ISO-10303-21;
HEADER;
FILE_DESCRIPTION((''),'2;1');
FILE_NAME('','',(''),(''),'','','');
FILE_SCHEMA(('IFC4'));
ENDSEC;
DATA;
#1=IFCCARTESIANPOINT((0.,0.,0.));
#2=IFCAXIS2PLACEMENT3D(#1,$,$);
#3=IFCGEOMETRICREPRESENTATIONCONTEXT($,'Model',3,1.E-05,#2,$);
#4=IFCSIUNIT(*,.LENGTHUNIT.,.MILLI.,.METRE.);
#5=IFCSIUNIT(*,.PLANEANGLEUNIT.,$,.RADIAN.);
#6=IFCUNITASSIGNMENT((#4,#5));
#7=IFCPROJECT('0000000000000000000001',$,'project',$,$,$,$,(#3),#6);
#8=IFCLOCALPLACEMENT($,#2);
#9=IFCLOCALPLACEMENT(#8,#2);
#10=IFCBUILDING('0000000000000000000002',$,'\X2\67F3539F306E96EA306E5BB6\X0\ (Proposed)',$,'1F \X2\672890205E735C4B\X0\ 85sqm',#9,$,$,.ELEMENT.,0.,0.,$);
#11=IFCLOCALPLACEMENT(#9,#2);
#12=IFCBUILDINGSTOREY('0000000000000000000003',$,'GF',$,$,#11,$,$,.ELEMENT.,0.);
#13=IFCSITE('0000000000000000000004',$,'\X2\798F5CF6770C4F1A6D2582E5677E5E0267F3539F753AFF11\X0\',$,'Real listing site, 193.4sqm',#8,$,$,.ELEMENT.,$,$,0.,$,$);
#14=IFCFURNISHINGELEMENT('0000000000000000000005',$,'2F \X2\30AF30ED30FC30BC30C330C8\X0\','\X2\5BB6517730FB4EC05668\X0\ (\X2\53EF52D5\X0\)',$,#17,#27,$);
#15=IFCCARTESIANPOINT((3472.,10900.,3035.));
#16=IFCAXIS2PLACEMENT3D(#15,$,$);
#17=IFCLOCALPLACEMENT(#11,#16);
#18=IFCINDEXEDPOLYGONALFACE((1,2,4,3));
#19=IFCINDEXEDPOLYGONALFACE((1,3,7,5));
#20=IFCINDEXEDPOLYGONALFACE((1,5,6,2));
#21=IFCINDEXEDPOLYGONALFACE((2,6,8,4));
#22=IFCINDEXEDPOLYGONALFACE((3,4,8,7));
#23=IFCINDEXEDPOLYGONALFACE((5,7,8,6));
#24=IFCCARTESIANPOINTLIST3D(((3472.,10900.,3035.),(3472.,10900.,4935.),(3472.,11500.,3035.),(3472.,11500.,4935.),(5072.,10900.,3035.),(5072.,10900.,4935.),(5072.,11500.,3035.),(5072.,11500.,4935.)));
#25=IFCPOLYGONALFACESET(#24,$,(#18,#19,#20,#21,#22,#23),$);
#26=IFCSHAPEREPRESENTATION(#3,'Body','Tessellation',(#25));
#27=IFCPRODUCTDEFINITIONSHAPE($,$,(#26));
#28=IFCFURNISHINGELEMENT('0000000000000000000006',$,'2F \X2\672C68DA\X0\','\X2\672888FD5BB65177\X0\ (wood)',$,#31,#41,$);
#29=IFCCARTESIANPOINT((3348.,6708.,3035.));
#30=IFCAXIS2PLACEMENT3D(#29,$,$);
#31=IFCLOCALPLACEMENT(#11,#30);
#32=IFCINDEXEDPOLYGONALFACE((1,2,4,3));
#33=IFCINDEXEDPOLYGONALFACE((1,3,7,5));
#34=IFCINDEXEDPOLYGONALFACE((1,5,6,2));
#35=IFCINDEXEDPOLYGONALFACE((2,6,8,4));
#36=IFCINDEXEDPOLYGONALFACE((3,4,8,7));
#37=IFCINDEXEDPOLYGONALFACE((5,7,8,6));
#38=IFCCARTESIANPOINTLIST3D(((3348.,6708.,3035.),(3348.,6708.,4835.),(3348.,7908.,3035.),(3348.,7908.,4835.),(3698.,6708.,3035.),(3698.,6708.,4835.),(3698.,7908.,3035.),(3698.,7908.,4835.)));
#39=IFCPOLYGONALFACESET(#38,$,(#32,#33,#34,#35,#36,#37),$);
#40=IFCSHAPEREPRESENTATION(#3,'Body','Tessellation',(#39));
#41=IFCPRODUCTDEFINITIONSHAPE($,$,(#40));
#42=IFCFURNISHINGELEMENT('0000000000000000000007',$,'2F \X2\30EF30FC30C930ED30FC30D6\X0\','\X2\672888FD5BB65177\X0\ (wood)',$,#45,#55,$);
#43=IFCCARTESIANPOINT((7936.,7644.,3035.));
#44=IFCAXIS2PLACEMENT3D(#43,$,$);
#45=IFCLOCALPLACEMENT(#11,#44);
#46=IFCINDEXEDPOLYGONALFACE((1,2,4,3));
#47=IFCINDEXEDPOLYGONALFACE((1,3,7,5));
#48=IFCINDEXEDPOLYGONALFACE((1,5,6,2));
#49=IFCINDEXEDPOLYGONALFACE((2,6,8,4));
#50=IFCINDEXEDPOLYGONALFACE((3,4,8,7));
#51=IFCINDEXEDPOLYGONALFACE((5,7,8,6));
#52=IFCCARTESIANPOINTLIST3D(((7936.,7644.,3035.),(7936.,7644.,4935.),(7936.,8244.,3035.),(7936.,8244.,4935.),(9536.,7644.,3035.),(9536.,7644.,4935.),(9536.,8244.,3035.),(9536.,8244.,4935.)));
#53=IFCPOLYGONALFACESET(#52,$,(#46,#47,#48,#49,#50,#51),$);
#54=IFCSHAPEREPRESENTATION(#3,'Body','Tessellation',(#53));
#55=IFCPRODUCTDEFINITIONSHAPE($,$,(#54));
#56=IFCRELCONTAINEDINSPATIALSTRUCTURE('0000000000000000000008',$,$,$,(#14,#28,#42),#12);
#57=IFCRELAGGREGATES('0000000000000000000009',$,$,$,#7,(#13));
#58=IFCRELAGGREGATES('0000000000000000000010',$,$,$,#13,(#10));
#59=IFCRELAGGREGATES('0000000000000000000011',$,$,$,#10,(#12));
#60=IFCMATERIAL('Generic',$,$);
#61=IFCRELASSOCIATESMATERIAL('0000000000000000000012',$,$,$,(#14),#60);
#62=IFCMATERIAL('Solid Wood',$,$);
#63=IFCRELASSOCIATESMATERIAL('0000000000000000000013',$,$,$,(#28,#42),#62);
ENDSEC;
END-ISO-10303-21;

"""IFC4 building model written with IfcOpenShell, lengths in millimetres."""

from ifc_helpers import new_model, si_unit, frame, frame_2d, origin, place, context, project, spatial, rectangle, extrude, material, element, save


model = new_model("IFC4")

# Units and contexts
model_context = context("Model", 3, precision=1e-05, world=origin())
ifc_project = project(units=[si_unit("LENGTHUNIT", "METRE", prefix="MILLI"), si_unit("PLANEANGLEUNIT", "RADIAN")], contexts=[model_context])

# Site, building, storey
site_placement = place(None, origin())
site = spatial("IfcSite", under=ifc_project, at=site_placement, Name="福島県会津若松市柳原町１", ObjectType="Real listing site, 193.4sqm", CompositionType="ELEMENT", RefElevation=0.0)
building_placement = place(site_placement, origin())
building = spatial("IfcBuilding", under=site, at=building_placement, Name="柳原の雪の家 (Proposed)", ObjectType="1F 木造平屋 85sqm", CompositionType="ELEMENT", ElevationOfRefHeight=0.0, ElevationOfTerrain=0.0)
storey_placement = place(building_placement, origin())
storey = spatial("IfcBuildingStorey", under=building, at=storey_placement, Name="GF", CompositionType="ELEMENT", Elevation=0.0)

# Shared definitions
ifc_material_1 = material(Name="Solid Wood")

# Shared definitions
ifc_material_2 = material(Name="Generic")

# Furnishing elements
furnishing_1_placement = place(storey_placement, frame((3472.0, 10900.0, 3035.0)))
element("IfcFurnishingElement", 1, at=furnishing_1_placement, inside=storey, material=ifc_material_2, Name="2F クローゼット", Description="家具・什器 (可動)", context=model_context, shape_type="SweptSolid", body=[
    extrude(rectangle(XDim=1600.0, YDim=600.0, at=frame_2d((800.0, 300.0))), frame((3472.0, 10900.0, 3035.0)), (0.0, 0.0, 1.0), 1900.0),
])
furnishing_2_placement = place(storey_placement, frame((3348.0, 6708.0, 3035.0)))
element("IfcFurnishingElement", 2, at=furnishing_2_placement, inside=storey, material=ifc_material_1, Name="2F 本棚", Description="木製家具 (wood)", context=model_context, shape_type="SweptSolid", body=[
    extrude(rectangle(XDim=350.0, YDim=1200.0, at=frame_2d((175.0, 600.0))), frame((3348.0, 6708.0, 3035.0)), (0.0, 0.0, 1.0), 1800.0),
])
furnishing_3_placement = place(storey_placement, frame((7936.0, 7644.0, 3035.0)))
element("IfcFurnishingElement", 3, at=furnishing_3_placement, inside=storey, material=ifc_material_1, Name="2F ワードローブ", Description="木製家具 (wood)", context=model_context, shape_type="SweptSolid", body=[
    extrude(rectangle(XDim=1600.0, YDim=600.0, at=frame_2d((800.0, 300.0))), frame((7936.0, 7644.0, 3035.0)), (0.0, 0.0, 1.0), 1900.0),
])

save(model, "model.ifc")
